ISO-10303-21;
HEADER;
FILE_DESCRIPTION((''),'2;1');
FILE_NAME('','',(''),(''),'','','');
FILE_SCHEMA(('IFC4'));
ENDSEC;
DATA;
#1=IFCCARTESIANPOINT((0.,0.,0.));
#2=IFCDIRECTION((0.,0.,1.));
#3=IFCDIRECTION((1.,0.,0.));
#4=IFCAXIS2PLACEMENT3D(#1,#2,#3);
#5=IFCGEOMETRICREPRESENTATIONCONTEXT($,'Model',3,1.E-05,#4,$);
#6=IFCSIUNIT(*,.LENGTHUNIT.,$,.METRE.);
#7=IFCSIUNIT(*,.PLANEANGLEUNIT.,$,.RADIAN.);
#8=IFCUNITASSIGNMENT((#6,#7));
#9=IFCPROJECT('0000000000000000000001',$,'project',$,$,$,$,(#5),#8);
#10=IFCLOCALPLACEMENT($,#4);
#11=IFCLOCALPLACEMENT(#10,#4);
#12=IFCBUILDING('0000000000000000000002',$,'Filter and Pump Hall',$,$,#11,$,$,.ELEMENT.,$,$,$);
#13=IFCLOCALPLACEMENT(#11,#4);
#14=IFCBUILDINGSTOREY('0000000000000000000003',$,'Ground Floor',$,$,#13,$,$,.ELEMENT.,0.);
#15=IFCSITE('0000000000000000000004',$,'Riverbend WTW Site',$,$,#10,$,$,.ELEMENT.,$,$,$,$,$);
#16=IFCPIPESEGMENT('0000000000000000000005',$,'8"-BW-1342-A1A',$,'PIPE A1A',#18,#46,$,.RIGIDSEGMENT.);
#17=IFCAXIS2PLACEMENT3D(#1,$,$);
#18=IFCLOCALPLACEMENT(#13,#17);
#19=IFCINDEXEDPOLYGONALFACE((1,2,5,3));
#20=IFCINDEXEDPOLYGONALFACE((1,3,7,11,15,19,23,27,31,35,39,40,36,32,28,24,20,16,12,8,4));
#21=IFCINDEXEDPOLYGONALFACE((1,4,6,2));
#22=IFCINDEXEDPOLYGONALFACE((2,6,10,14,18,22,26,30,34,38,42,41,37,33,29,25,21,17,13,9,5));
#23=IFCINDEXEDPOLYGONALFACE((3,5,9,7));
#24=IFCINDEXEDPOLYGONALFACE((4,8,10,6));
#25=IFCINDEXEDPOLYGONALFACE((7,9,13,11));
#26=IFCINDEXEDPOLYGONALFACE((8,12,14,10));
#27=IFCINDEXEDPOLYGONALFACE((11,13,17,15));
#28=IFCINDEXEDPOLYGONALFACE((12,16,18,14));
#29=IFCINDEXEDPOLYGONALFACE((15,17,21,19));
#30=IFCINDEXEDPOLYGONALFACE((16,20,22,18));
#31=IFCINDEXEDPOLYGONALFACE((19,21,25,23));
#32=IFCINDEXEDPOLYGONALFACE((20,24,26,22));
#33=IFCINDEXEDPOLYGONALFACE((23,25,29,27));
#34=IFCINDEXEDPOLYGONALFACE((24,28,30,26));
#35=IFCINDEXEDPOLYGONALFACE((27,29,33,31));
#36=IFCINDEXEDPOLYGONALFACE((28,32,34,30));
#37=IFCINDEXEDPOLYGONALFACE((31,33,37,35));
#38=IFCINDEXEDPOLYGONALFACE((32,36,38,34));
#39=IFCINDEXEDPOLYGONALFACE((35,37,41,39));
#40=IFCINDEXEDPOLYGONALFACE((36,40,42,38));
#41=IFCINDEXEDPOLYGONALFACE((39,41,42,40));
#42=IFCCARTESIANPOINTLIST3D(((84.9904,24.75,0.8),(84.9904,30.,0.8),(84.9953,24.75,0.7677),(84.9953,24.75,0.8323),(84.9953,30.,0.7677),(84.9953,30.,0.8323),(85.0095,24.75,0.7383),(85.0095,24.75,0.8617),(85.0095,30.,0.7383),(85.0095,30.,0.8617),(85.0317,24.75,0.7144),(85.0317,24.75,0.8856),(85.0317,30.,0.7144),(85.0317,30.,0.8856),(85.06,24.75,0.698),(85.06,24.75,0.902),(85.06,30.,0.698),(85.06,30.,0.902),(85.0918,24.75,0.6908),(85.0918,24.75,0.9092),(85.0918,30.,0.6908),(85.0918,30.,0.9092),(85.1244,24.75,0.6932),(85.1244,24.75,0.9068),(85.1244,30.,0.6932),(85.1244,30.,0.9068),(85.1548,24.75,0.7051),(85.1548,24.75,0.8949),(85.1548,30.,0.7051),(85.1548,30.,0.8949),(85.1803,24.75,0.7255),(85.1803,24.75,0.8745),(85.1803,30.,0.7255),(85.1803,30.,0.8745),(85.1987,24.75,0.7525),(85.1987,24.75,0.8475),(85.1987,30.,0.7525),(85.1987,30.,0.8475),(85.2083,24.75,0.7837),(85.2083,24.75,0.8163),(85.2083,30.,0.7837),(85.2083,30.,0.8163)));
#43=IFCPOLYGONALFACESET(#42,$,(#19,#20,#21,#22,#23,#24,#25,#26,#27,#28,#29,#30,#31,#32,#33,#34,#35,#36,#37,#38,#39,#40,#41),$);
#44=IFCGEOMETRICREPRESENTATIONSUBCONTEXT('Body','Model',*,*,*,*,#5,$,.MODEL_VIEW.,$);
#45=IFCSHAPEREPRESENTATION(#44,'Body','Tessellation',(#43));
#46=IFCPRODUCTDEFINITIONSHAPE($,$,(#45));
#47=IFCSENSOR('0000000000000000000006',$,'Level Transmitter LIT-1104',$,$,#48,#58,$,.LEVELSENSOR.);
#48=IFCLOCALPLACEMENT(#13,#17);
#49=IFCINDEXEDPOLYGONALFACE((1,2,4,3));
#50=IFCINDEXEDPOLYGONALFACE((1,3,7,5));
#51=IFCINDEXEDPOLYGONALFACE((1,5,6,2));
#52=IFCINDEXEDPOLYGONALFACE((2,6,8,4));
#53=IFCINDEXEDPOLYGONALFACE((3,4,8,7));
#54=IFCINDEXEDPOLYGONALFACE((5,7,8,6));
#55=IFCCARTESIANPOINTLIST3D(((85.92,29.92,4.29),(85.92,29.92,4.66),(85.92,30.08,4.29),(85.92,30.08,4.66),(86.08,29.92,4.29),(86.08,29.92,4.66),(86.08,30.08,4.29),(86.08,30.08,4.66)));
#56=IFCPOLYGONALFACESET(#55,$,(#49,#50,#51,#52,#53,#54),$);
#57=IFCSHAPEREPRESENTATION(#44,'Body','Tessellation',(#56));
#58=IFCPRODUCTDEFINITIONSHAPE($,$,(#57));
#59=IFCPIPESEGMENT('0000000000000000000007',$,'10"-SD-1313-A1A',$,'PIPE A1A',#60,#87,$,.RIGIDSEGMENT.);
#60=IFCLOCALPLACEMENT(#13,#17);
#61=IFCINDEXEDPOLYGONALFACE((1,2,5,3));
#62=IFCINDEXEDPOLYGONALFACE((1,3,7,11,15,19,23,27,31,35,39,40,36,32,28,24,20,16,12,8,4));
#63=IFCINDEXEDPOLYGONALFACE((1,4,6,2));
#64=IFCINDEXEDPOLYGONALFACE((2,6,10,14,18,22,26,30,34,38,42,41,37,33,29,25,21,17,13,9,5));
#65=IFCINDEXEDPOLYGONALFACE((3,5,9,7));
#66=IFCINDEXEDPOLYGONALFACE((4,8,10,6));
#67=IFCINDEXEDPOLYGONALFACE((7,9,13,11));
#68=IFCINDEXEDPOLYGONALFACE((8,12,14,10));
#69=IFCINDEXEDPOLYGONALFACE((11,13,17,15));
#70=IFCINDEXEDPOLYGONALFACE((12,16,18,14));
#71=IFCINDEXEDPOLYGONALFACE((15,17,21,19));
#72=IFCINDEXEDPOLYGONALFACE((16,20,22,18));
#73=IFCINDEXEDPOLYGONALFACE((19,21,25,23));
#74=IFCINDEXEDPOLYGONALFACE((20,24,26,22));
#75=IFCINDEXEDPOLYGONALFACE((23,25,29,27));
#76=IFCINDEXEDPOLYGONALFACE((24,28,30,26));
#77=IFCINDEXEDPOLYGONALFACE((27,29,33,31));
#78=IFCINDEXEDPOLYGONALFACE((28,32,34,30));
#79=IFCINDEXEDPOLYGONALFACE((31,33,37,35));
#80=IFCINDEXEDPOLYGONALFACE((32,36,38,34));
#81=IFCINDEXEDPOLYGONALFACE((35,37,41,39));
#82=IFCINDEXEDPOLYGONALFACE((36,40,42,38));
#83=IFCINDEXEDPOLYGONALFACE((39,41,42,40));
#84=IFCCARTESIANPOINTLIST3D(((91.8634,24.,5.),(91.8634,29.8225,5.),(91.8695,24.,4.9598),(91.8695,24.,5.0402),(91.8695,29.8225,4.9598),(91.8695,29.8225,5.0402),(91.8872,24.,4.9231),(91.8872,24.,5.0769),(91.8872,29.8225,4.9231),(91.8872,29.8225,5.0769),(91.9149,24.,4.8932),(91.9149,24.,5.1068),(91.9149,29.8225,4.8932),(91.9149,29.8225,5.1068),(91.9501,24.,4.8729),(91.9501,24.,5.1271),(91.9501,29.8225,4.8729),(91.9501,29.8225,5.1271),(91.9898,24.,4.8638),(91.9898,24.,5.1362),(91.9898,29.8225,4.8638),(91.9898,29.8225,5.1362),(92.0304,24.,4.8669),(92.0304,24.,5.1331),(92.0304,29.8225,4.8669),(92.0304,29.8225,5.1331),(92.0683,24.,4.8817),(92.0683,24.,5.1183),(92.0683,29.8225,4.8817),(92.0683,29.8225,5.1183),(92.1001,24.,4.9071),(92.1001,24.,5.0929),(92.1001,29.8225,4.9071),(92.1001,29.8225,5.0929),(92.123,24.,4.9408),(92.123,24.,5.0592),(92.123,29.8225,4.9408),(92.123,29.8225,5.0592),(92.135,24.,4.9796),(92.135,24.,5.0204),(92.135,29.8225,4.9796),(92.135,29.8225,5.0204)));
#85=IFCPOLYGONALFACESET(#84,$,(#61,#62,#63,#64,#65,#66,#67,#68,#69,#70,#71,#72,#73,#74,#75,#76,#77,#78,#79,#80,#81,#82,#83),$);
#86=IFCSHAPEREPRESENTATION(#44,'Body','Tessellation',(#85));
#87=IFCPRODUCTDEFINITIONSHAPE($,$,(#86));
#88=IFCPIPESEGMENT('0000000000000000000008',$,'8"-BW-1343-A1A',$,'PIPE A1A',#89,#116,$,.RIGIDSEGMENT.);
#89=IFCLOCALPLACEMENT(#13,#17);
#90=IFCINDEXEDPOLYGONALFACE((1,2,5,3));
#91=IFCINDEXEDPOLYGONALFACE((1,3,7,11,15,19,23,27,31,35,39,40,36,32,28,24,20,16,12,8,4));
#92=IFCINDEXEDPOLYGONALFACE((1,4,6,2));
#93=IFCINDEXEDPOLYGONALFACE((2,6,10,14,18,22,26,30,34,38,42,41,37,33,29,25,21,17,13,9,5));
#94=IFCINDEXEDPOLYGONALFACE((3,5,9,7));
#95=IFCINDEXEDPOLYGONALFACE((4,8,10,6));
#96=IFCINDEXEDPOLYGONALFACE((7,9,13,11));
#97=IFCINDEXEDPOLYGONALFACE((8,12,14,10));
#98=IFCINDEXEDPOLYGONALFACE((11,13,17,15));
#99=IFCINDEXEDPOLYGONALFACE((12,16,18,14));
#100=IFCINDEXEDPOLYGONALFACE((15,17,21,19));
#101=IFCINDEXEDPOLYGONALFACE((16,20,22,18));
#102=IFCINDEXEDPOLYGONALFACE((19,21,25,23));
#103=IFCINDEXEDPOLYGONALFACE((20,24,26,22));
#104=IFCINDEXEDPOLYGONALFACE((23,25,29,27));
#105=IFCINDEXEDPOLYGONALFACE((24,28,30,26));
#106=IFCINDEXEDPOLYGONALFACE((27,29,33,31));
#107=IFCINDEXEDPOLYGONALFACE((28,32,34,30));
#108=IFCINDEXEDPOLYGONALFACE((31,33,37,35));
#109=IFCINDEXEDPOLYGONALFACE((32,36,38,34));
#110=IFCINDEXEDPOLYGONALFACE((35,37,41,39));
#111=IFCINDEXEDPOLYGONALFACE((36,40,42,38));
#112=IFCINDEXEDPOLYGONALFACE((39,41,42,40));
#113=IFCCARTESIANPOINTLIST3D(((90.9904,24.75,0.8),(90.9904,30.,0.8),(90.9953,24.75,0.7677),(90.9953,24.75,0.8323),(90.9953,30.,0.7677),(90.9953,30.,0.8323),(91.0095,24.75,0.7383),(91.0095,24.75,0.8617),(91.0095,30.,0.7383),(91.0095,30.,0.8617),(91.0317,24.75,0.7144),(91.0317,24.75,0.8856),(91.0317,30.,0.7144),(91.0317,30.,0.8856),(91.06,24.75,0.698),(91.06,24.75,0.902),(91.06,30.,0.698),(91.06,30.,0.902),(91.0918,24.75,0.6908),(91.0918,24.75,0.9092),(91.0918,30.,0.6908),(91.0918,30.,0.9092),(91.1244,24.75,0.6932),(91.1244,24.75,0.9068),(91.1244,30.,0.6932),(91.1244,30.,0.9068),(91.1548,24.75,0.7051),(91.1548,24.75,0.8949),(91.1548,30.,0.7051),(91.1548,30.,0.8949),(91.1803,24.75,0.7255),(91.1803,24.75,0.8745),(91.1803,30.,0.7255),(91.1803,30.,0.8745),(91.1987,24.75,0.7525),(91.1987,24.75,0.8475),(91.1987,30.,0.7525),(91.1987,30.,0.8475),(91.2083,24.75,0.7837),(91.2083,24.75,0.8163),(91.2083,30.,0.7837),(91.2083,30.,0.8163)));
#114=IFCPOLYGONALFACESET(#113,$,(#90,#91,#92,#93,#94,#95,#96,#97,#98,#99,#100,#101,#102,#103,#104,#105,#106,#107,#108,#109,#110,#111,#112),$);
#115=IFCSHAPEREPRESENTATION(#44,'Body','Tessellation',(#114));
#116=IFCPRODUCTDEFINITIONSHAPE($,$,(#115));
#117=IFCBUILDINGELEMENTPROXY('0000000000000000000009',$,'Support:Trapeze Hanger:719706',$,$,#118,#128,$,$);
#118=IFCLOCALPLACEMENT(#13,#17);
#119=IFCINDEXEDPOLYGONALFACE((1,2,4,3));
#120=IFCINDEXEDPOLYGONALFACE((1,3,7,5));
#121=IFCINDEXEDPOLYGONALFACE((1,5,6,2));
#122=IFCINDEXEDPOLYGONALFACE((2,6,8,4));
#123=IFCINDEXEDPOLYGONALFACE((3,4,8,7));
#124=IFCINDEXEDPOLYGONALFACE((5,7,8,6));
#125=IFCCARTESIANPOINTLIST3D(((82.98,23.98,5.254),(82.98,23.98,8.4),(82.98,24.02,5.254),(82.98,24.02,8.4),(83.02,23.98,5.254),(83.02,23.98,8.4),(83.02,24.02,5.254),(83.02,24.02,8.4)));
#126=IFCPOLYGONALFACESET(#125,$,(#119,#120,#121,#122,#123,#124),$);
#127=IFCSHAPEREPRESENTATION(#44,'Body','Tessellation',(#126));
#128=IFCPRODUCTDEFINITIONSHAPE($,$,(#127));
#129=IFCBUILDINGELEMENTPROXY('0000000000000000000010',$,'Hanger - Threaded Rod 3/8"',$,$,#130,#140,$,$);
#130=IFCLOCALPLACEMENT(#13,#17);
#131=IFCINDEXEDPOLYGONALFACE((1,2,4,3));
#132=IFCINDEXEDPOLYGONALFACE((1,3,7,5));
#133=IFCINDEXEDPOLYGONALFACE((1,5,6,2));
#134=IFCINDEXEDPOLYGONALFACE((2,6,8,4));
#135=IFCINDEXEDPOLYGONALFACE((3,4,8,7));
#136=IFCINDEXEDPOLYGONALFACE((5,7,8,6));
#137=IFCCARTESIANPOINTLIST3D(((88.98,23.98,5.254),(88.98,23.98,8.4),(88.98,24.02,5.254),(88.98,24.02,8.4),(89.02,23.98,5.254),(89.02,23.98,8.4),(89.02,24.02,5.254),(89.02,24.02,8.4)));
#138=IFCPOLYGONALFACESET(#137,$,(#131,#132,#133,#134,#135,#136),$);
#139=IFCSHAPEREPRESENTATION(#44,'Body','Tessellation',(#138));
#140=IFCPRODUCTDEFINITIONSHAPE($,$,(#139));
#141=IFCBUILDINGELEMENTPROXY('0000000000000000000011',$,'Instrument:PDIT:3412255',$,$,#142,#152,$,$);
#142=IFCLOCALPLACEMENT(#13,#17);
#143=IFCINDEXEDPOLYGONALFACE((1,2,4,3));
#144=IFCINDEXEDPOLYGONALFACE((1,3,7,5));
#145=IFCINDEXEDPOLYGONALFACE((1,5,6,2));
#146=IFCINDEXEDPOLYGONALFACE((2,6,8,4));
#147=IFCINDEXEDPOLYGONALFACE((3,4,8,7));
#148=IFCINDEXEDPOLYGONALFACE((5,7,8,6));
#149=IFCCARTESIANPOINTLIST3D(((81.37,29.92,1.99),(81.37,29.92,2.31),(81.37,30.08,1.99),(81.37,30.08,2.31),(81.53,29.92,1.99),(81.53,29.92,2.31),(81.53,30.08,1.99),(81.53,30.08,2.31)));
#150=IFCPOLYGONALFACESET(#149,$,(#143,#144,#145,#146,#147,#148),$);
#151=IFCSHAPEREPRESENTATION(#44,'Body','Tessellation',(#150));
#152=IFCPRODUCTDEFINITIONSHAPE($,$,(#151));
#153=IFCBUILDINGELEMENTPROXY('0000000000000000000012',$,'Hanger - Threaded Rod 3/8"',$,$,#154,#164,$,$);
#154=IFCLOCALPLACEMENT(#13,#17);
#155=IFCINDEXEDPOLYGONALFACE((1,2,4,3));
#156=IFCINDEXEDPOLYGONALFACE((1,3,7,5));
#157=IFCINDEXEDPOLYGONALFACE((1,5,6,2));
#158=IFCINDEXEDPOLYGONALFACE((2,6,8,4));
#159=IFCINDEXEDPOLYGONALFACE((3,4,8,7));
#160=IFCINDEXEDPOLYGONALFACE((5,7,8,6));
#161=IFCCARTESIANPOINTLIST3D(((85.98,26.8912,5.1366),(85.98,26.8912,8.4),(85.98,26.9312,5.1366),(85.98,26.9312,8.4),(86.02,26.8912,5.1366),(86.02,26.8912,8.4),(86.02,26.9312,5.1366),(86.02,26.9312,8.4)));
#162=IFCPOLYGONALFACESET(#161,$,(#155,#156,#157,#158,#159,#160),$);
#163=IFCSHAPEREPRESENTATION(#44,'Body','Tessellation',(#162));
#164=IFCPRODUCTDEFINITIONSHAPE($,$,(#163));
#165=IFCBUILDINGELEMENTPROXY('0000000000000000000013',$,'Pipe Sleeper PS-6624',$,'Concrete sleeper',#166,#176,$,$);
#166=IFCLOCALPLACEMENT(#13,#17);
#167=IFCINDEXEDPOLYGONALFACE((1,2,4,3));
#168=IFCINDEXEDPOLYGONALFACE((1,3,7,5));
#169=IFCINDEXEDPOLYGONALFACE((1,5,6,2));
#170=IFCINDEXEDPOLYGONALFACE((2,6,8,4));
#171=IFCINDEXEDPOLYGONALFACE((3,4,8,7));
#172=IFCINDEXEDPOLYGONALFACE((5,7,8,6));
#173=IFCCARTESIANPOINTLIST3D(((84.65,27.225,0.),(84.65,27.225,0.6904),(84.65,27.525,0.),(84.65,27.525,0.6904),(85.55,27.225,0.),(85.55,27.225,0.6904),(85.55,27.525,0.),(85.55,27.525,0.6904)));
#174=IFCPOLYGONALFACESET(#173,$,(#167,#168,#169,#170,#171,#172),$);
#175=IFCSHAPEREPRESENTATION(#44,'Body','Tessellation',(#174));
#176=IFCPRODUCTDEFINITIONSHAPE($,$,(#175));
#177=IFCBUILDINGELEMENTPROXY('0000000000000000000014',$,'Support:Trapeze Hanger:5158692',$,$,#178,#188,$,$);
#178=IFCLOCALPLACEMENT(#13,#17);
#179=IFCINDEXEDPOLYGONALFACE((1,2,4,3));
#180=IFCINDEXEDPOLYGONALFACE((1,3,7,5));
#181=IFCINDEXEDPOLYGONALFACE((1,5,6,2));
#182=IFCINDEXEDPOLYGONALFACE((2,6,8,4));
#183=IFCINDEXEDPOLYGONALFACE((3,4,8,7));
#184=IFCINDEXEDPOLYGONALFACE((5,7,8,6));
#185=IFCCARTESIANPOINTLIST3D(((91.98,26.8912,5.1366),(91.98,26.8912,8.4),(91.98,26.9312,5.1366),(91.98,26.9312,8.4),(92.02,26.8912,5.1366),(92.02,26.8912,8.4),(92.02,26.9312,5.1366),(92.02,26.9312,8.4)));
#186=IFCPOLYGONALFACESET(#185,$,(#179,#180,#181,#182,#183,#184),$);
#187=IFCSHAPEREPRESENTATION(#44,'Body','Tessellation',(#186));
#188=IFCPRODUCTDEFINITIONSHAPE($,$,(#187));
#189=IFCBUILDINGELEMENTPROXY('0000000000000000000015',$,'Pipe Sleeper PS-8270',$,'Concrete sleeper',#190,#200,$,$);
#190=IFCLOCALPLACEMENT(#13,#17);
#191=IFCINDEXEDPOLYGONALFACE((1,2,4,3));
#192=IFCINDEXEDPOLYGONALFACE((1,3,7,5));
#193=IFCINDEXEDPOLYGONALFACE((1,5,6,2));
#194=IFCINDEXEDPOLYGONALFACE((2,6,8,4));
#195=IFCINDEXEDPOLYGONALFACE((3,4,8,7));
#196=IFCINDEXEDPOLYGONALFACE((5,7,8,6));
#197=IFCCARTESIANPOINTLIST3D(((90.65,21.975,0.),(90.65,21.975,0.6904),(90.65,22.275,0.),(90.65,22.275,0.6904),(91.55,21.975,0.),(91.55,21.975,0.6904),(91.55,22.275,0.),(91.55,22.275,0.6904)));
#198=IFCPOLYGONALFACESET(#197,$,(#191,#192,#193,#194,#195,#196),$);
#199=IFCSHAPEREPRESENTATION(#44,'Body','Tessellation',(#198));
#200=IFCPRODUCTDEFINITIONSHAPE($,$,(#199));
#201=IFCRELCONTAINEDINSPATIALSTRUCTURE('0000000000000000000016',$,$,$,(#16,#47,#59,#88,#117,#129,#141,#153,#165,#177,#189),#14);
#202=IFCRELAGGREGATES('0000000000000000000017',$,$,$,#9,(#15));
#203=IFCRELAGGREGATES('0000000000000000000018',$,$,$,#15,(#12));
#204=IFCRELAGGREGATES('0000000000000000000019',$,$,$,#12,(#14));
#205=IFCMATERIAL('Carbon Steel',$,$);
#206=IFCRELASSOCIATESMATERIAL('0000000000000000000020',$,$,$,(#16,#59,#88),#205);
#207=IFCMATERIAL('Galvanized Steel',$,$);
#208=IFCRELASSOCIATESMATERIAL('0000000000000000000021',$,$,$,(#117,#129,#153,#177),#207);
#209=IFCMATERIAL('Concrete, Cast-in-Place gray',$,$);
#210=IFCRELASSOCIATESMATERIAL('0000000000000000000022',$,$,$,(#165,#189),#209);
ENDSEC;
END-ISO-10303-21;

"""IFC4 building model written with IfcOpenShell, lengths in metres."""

from ifc_helpers import new_model, si_unit, frame, origin_with_axes, origin_2d, place, context, subcontext, project, spatial, rectangle, circle, extrude, material, element, save


model = new_model("IFC4")

# Units and contexts
model_context = context("Model", 3, precision=1e-05, world=origin_with_axes())
body_context = subcontext(model_context, "Body", "Model", "MODEL_VIEW")
ifc_project = project(units=[si_unit("LENGTHUNIT", "METRE"), si_unit("PLANEANGLEUNIT", "RADIAN")], contexts=[model_context])

# Site, building, storey
site_placement = place(None, origin_with_axes())
site = spatial("IfcSite", under=ifc_project, at=site_placement, Name="Riverbend WTW Site", CompositionType="ELEMENT")
building_placement = place(site_placement, origin_with_axes())
building = spatial("IfcBuilding", under=site, at=building_placement, Name="Filter and Pump Hall", CompositionType="ELEMENT")
storey_placement = place(building_placement, origin_with_axes())
storey = spatial("IfcBuildingStorey", under=building, at=storey_placement, Name="Ground Floor", CompositionType="ELEMENT", Elevation=0.0)

# Shared definitions
ifc_material_1 = material(Name="Concrete, Cast-in-Place gray")

# Shared definitions
ifc_material_2 = material(Name="Carbon Steel")

# Pipe segment
pipe_segment_1_placement = place(None, frame((85.1, 24.75, 0.8), z_axis=(0.0, 0.0, 1.0), x_axis=(1.0, 0.0, 0.0)))
element("IfcPipeSegment", 1, at=pipe_segment_1_placement, inside=storey, material=ifc_material_2, Name="8\"-BW-1342-A1A", ObjectType="PIPE A1A", PredefinedType="RIGIDSEGMENT", context=body_context, shape_type="SweptSolid", body=[
    extrude(circle(Radius=0.1095, at=origin_2d()), frame((0.0, 0.0, 0.0), z_axis=(0.0, 1.0, 0.0), x_axis=(-1.0, 0.0, 0.0)), (0.0, 0.0, 1.0), 5.25),
])

# Sensor
sensor_placement = place(None, frame((86.0, 30.0, 4.475), z_axis=(0.0, 0.0, 1.0), x_axis=(1.0, 0.0, 0.0)))
element("IfcSensor", 2, at=sensor_placement, inside=storey, Name="Level Transmitter LIT-1104", PredefinedType="LEVELSENSOR", context=body_context, shape_type="SweptSolid", body=[
    extrude(rectangle(XDim=0.16, YDim=0.16, at=origin_2d()), frame((0.0, 0.0, -0.185), z_axis=(0.0, 0.0, 1.0), x_axis=(1.0, 0.0, 0.0)), (0.0, 0.0, 1.0), 0.37),
])

# Pipe segments
pipe_segment_2_placement = place(None, frame((92.0, 24.0, 5.0), z_axis=(0.0, 0.0, 1.0), x_axis=(1.0, 0.0, 0.0)))
element("IfcPipeSegment", 3, at=pipe_segment_2_placement, inside=storey, material=ifc_material_2, Name="10\"-SD-1313-A1A", ObjectType="PIPE A1A", PredefinedType="RIGIDSEGMENT", context=body_context, shape_type="SweptSolid", body=[
    extrude(circle(Radius=0.1366, at=origin_2d()), frame((0.0, 0.0, 0.0), z_axis=(0.0, 1.0, 0.0), x_axis=(-1.0, 0.0, 0.0)), (0.0, 0.0, 1.0), 5.8225),
])
pipe_segment_3_placement = place(None, frame((91.1, 24.75, 0.8), z_axis=(0.0, 0.0, 1.0), x_axis=(1.0, 0.0, 0.0)))
element("IfcPipeSegment", 4, at=pipe_segment_3_placement, inside=storey, material=ifc_material_2, Name="8\"-BW-1343-A1A", ObjectType="PIPE A1A", PredefinedType="RIGIDSEGMENT", context=body_context, shape_type="SweptSolid", body=[
    extrude(circle(Radius=0.1095, at=origin_2d()), frame((0.0, 0.0, 0.0), z_axis=(0.0, 1.0, 0.0), x_axis=(-1.0, 0.0, 0.0)), (0.0, 0.0, 1.0), 5.25),
])

# Building element proxies
ifc_material_3 = material(Name="Galvanized Steel")
for number, where, z_axis, x_axis, name in (
    (5, (83.0, 24.0, 6.827), (0.0, 0.0, 1.0), (1.0, 0.0, 0.0), "Support:Trapeze Hanger:719706"),
    (6, (89.0, 24.0, 6.827), (0.0, 0.0, 1.0), (1.0, 0.0, 0.0), "Hanger - Threaded Rod 3/8\""),
):
    element("IfcBuildingElementProxy", number, at=place(None, frame(where, z_axis=z_axis, x_axis=x_axis)), inside=storey, material=ifc_material_3, Name=name, context=body_context, shape_type="SweptSolid", body=[
        extrude(rectangle(XDim=0.04, YDim=0.04, at=origin_2d()), frame((0.0, 0.0, -1.573), z_axis=(0.0, 0.0, 1.0), x_axis=(1.0, 0.0, 0.0)), (0.0, 0.0, 1.0), 3.146),
    ])
proxy_1_placement = place(None, frame((81.45, 30.0, 2.15), z_axis=(0.0, 0.0, 1.0), x_axis=(1.0, 0.0, 0.0)))
element("IfcBuildingElementProxy", 7, at=proxy_1_placement, inside=storey, Name="Instrument:PDIT:3412255", context=body_context, shape_type="SweptSolid", body=[
    extrude(rectangle(XDim=0.16, YDim=0.16, at=origin_2d()), frame((0.0, 0.0, -0.16), z_axis=(0.0, 0.0, 1.0), x_axis=(1.0, 0.0, 0.0)), (0.0, 0.0, 1.0), 0.32),
])
proxy_2_placement = place(None, frame((86.0, 26.9112, 6.7683), z_axis=(0.0, 0.0, 1.0), x_axis=(1.0, 0.0, 0.0)))
element("IfcBuildingElementProxy", 8, at=proxy_2_placement, inside=storey, material=ifc_material_3, Name="Hanger - Threaded Rod 3/8\"", context=body_context, shape_type="SweptSolid", body=[
    extrude(rectangle(XDim=0.04, YDim=0.04, at=origin_2d()), frame((0.0, 0.0, -1.6317), z_axis=(0.0, 0.0, 1.0), x_axis=(1.0, 0.0, 0.0)), (0.0, 0.0, 1.0), 3.2635),
])
proxy_3_placement = place(None, frame((85.1, 27.375, 0.3452), z_axis=(0.0, 0.0, 1.0), x_axis=(1.0, 0.0, 0.0)))
element("IfcBuildingElementProxy", 9, at=proxy_3_placement, inside=storey, material=ifc_material_1, Name="Pipe Sleeper PS-6624", ObjectType="Concrete sleeper", context=body_context, shape_type="SweptSolid", body=[
    extrude(rectangle(XDim=0.9, YDim=0.3, at=origin_2d()), frame((0.0, 0.0, -0.3452), z_axis=(0.0, 0.0, 1.0), x_axis=(1.0, 0.0, 0.0)), (0.0, 0.0, 1.0), 0.6905),
])
proxy_4_placement = place(None, frame((92.0, 26.9112, 6.7683), z_axis=(0.0, 0.0, 1.0), x_axis=(1.0, 0.0, 0.0)))
element("IfcBuildingElementProxy", 10, at=proxy_4_placement, inside=storey, material=ifc_material_3, Name="Support:Trapeze Hanger:5158692", context=body_context, shape_type="SweptSolid", body=[
    extrude(rectangle(XDim=0.04, YDim=0.04, at=origin_2d()), frame((0.0, 0.0, -1.6317), z_axis=(0.0, 0.0, 1.0), x_axis=(1.0, 0.0, 0.0)), (0.0, 0.0, 1.0), 3.2635),
])
for number, where, z_axis, x_axis, name in (
    (11, (91.1, 22.125, 0.3452), (0.0, 0.0, 1.0), (1.0, 0.0, 0.0), "Pipe Sleeper PS-8270"),
):
    element("IfcBuildingElementProxy", number, at=place(None, frame(where, z_axis=z_axis, x_axis=x_axis)), inside=storey, material=ifc_material_1, Name=name, ObjectType="Concrete sleeper", context=body_context, shape_type="SweptSolid", body=[
        extrude(rectangle(XDim=0.9, YDim=0.3, at=origin_2d()), frame((0.0, 0.0, -0.3452), z_axis=(0.0, 0.0, 1.0), x_axis=(1.0, 0.0, 0.0)), (0.0, 0.0, 1.0), 0.6905),
    ])

save(model, "model.ifc")
